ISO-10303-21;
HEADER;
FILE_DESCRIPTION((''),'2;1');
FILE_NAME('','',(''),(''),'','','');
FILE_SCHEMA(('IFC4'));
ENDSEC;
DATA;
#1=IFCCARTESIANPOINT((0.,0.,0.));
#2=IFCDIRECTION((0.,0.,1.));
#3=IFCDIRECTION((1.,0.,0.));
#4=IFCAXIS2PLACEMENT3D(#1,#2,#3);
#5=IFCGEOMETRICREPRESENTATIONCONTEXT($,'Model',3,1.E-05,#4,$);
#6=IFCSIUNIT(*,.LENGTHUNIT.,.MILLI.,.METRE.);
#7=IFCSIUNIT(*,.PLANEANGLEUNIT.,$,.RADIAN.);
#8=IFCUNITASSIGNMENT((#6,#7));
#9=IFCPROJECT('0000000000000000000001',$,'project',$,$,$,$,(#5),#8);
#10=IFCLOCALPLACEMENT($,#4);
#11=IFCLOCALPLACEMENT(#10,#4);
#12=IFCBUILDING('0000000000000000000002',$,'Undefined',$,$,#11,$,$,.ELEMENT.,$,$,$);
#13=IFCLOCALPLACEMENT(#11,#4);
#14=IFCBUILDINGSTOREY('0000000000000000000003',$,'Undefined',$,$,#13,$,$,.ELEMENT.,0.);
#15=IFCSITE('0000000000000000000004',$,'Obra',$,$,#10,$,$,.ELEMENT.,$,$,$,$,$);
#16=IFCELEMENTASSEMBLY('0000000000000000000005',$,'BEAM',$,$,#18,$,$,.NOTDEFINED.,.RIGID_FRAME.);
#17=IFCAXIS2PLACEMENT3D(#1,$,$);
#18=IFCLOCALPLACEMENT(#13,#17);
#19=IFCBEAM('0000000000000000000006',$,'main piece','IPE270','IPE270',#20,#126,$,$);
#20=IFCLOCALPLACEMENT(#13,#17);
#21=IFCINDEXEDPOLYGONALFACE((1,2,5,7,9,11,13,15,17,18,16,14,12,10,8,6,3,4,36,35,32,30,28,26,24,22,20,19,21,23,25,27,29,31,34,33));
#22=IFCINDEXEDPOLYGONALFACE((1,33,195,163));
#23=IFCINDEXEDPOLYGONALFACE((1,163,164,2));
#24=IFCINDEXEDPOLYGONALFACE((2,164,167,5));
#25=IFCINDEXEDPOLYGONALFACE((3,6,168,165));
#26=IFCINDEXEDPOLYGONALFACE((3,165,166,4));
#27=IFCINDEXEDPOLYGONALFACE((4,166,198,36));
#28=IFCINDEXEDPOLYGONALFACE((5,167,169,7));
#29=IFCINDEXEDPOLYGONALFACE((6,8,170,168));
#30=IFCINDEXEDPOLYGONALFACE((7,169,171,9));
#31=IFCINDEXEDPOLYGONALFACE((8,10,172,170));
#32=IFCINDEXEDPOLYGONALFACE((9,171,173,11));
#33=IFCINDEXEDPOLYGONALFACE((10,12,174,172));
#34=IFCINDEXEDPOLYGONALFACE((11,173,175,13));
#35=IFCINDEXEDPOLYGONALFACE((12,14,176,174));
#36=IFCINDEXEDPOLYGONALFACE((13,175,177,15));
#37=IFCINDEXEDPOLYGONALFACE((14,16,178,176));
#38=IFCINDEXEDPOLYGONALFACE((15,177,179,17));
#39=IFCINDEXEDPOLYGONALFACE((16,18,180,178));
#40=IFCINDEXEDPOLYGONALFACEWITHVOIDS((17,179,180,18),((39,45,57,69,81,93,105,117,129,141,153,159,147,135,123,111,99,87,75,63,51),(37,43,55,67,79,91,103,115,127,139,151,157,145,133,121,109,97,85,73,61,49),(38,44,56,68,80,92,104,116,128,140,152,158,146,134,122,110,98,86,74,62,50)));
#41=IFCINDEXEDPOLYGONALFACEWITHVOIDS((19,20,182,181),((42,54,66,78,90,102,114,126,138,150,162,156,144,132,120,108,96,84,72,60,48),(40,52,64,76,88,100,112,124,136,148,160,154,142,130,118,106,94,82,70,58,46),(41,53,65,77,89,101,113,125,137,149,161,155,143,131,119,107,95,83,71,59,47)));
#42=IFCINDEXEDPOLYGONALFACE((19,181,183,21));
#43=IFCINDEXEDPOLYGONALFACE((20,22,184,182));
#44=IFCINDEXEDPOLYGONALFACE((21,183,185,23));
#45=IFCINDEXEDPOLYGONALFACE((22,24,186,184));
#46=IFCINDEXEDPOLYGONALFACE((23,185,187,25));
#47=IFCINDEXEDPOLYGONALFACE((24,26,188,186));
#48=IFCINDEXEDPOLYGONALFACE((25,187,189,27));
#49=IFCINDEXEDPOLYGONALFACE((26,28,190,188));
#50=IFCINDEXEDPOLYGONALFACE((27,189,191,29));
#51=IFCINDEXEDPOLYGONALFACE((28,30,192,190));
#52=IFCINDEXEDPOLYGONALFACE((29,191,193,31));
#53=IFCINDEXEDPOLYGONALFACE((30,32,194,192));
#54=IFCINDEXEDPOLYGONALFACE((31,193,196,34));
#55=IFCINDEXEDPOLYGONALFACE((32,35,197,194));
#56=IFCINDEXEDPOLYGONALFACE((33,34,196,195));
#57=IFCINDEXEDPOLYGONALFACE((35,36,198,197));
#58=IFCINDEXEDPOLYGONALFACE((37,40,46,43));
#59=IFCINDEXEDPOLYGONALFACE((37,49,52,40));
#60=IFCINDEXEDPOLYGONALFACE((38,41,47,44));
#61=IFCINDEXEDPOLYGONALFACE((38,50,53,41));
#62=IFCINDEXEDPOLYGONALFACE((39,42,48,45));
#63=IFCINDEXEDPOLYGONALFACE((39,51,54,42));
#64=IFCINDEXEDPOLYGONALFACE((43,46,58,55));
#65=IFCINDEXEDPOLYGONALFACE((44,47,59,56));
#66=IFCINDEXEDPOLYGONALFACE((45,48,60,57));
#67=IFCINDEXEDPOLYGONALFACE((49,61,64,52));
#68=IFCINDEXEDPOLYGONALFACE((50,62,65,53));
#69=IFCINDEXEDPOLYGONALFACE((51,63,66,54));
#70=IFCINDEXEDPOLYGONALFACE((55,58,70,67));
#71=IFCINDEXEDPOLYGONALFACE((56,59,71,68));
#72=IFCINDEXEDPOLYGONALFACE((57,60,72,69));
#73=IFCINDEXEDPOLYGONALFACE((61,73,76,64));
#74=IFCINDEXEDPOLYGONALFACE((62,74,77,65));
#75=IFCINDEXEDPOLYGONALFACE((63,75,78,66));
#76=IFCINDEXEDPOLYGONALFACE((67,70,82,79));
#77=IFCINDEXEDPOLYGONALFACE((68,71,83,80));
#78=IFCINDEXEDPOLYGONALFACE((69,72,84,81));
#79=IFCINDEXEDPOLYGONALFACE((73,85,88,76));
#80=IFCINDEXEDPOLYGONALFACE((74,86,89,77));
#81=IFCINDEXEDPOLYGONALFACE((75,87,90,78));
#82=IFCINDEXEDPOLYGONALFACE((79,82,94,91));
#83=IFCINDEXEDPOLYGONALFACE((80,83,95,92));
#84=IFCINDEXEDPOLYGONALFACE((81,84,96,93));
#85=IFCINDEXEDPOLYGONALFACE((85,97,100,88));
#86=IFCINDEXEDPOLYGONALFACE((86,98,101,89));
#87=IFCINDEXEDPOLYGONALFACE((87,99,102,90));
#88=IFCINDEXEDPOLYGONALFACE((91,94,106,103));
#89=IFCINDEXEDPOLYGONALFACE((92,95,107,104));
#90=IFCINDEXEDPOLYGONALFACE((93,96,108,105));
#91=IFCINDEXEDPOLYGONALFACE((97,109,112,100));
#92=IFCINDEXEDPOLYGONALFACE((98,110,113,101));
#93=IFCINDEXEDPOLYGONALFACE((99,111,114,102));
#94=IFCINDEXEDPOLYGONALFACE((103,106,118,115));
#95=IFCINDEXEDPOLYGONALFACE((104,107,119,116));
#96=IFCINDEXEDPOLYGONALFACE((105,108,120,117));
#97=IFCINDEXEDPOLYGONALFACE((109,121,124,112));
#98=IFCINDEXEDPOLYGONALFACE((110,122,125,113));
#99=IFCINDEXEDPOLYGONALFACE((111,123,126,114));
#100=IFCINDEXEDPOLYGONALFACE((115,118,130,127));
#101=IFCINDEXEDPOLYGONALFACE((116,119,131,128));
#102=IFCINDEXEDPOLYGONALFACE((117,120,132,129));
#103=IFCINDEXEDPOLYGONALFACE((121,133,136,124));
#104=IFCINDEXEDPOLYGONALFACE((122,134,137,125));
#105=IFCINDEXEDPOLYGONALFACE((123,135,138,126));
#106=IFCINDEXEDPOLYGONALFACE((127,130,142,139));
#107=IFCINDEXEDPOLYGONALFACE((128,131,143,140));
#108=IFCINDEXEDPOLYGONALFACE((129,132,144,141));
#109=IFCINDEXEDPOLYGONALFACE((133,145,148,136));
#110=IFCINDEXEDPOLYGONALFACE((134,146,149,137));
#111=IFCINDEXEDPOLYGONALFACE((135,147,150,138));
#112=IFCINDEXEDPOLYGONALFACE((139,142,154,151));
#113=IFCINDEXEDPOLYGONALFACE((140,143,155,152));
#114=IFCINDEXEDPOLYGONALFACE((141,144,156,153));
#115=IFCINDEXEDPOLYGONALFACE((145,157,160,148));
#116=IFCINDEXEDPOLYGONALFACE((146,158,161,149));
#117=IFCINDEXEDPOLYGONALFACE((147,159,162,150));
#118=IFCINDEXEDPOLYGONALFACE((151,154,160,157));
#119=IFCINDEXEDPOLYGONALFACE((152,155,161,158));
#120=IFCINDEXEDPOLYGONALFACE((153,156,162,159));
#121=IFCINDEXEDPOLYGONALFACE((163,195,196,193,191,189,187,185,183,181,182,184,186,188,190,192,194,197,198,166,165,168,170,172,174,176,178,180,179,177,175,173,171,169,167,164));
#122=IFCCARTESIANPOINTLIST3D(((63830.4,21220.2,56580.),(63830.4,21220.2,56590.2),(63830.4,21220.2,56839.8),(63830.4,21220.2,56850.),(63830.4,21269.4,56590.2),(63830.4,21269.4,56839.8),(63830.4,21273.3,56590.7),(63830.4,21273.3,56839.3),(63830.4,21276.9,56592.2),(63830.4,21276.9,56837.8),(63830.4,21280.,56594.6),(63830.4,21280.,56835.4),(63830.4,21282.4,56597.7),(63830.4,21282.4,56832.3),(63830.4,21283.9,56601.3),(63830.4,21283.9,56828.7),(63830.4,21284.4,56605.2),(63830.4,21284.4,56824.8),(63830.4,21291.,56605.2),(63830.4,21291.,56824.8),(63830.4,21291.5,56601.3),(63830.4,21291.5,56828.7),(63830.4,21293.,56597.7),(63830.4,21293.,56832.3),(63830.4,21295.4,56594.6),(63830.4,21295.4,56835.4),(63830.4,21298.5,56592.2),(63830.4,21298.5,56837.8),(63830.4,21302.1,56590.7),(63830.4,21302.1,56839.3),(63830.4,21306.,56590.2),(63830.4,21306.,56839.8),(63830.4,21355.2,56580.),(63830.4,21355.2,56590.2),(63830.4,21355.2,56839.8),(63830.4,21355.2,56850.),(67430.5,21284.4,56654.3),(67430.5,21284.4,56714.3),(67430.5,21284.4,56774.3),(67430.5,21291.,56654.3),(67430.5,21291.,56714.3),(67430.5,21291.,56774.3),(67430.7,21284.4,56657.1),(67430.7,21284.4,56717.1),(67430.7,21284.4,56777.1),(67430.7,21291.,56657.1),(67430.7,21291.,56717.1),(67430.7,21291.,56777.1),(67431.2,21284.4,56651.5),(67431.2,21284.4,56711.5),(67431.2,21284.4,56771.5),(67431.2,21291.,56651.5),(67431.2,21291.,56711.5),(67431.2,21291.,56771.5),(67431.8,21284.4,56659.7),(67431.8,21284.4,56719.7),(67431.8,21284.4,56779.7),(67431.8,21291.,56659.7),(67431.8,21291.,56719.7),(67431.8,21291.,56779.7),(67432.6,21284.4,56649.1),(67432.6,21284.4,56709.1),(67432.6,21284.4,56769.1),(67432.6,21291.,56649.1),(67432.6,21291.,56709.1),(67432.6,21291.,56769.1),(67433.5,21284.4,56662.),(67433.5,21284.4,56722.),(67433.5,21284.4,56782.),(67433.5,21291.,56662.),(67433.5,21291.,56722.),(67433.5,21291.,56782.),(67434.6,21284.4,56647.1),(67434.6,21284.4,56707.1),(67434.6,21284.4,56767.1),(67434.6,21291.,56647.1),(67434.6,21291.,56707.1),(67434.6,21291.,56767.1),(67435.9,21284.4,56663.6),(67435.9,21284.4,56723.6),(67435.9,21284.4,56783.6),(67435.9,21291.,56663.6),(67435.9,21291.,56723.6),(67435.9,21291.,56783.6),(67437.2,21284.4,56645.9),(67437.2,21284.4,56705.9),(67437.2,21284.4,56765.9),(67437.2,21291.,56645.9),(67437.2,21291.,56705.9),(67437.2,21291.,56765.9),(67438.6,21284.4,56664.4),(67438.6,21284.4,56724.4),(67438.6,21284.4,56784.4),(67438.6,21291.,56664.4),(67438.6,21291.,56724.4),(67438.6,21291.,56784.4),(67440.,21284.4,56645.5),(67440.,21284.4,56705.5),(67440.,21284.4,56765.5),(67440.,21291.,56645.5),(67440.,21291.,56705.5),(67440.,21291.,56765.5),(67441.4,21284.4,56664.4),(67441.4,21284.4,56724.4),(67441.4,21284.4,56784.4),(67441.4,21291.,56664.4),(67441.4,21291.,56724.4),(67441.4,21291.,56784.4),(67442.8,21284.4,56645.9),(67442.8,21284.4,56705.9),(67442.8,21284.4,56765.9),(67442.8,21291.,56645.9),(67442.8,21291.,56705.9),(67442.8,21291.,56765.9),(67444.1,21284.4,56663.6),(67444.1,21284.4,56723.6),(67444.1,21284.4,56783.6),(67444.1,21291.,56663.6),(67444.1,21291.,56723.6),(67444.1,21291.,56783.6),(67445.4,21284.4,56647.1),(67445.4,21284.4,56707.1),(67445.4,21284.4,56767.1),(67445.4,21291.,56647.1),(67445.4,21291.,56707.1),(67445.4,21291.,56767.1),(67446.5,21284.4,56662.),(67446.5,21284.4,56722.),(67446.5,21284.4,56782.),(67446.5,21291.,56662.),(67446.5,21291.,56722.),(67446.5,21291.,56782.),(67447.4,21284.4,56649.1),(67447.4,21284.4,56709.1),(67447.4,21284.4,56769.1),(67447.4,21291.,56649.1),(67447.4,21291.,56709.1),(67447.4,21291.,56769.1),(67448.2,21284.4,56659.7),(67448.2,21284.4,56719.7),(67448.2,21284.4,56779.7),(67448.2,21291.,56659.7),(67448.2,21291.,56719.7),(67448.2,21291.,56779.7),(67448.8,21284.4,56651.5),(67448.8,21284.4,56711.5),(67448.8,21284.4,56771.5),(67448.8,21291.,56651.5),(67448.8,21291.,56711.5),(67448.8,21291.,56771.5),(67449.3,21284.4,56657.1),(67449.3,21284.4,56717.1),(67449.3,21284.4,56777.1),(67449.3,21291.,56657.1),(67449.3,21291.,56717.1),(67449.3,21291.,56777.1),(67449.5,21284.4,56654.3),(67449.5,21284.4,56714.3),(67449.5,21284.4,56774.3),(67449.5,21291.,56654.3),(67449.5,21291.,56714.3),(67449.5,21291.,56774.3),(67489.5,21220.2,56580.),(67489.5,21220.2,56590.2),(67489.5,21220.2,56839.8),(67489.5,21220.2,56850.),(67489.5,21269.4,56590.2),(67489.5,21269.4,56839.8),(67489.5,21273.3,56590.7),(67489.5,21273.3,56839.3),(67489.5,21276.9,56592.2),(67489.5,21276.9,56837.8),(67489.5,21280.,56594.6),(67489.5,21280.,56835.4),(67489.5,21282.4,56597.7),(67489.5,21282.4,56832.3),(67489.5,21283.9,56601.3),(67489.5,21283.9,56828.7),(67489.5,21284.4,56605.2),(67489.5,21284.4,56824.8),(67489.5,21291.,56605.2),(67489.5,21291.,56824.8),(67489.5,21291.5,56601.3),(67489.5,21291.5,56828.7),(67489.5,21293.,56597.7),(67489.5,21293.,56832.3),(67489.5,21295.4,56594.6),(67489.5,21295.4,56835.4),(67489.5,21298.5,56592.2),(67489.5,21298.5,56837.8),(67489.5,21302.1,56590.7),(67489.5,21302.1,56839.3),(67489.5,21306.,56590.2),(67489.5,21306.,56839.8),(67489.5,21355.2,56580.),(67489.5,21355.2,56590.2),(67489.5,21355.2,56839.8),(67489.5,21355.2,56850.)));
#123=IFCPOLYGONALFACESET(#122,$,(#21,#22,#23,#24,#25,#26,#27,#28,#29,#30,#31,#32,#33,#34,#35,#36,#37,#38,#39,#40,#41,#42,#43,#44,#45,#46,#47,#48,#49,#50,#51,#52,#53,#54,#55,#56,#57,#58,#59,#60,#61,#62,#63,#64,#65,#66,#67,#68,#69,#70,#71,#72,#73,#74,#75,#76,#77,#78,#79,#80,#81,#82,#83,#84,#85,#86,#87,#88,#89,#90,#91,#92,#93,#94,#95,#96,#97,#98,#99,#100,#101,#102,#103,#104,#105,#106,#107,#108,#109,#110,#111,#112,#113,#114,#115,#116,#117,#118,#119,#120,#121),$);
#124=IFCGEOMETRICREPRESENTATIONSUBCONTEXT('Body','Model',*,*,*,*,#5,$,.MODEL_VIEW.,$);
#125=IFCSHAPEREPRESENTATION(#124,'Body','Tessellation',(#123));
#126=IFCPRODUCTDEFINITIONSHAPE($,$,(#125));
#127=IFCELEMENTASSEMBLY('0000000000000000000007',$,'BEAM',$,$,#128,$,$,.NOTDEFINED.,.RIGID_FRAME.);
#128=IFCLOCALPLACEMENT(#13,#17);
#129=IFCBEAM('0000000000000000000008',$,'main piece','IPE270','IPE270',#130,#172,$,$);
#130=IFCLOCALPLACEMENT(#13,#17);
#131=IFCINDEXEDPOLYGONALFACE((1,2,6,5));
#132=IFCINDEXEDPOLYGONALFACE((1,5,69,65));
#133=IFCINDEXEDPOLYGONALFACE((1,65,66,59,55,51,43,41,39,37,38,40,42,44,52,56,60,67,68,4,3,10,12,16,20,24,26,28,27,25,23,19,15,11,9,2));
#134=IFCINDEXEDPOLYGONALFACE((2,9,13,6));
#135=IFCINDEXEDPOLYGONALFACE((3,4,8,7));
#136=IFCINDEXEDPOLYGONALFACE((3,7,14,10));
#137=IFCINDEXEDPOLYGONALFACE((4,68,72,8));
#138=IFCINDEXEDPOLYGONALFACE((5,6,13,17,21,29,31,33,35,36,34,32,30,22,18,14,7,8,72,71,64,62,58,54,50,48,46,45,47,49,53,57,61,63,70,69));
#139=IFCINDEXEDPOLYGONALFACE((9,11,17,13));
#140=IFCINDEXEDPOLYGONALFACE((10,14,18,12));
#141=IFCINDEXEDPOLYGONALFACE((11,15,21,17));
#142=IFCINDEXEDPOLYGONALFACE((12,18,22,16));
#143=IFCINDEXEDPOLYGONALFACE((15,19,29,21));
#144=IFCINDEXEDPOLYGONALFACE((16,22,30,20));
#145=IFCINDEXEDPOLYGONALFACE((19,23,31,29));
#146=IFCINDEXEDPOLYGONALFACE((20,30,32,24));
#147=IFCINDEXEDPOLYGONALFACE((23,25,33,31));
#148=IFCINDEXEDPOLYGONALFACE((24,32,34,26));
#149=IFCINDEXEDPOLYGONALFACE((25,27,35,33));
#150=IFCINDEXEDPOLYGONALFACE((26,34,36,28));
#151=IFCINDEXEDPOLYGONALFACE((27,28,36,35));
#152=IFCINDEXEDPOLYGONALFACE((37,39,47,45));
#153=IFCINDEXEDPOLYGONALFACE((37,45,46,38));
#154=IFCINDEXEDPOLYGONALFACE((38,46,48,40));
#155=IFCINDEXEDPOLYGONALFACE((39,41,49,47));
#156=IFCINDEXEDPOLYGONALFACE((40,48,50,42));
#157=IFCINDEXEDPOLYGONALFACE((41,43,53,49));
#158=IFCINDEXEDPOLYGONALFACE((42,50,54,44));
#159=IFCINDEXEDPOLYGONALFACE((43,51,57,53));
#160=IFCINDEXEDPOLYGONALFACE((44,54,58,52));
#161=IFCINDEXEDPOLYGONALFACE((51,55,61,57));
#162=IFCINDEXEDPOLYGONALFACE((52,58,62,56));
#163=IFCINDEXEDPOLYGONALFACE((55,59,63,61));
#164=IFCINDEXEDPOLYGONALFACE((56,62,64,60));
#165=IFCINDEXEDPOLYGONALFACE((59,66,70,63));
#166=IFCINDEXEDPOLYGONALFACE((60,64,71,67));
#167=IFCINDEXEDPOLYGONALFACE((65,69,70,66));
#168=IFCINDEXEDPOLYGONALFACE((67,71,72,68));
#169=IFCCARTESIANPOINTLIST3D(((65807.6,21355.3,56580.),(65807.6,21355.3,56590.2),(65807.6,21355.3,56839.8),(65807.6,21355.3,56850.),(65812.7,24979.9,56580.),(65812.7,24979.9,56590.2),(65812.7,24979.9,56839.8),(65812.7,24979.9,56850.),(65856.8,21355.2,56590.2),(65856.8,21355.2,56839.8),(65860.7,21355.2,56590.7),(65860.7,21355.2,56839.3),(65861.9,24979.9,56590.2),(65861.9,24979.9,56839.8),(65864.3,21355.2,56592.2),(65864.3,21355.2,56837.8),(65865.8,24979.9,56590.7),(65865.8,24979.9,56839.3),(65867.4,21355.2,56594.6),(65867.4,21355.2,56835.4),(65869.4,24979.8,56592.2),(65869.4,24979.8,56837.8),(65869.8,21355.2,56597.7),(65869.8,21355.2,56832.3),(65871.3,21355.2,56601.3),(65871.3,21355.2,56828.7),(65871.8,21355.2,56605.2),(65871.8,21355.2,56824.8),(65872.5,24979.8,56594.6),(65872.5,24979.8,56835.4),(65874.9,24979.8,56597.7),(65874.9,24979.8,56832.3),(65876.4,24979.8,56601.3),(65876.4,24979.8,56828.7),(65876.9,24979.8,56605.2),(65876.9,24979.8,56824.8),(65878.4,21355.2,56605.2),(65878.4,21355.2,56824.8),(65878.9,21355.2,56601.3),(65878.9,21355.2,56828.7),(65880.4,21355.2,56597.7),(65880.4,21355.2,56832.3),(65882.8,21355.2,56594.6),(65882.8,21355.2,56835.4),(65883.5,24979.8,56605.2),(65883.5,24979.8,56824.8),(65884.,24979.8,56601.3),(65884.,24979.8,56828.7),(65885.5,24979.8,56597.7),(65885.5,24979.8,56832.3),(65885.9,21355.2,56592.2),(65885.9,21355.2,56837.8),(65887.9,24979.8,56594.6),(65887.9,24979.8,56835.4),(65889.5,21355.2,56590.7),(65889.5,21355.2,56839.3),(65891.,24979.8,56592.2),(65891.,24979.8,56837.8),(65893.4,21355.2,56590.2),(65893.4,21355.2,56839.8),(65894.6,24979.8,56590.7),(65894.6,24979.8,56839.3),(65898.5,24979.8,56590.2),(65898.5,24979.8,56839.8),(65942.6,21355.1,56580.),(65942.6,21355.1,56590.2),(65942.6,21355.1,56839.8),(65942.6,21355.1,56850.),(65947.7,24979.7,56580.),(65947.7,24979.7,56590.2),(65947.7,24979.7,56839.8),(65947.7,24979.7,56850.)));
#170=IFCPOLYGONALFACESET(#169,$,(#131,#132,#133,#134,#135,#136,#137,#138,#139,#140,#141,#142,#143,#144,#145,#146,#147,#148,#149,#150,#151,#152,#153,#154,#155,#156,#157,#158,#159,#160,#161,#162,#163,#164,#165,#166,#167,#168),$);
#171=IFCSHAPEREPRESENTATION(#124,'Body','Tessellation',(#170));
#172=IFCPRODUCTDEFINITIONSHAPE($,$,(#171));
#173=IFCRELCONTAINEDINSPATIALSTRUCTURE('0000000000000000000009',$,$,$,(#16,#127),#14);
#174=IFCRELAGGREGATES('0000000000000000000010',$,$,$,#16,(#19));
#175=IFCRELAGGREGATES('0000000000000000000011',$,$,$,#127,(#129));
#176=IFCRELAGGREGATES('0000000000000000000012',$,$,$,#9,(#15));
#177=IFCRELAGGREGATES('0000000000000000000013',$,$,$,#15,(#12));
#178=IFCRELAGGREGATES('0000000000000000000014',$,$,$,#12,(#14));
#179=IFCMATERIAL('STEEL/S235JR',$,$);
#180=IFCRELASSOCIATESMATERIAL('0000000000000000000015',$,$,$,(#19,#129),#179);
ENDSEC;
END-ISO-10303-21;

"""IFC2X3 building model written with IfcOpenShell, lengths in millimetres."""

from ifc_helpers import new_model, si_unit, frame, origin_with_axes, origin_2d_with_axis, place, context, subcontext, project, spatial, circle, i_section, extrude, clip, halfspace, source, transform, mapped, material, element, aggregate, save


model = new_model("IFC2X3")

# Units and contexts
model_context = context("Model", 3, precision=1e-05, world=origin_with_axes())
body_context = subcontext(model_context, "Body", "Model", "MODEL_VIEW")
ifc_project = project(units=[si_unit("LENGTHUNIT", "METRE", prefix="MILLI"), si_unit("PLANEANGLEUNIT", "RADIAN")], contexts=[model_context])

# Site, building, storey
site_placement = place(None, origin_with_axes())
site = spatial("IfcSite", under=ifc_project, at=site_placement, Name="Obra", CompositionType="ELEMENT")
building_placement = place(site_placement, origin_with_axes())
building = spatial("IfcBuilding", under=site, at=building_placement, Name="Undefined", CompositionType="ELEMENT")
storey_placement = place(building_placement, origin_with_axes())
storey = spatial("IfcBuildingStorey", under=building, at=storey_placement, Name="Undefined", CompositionType="ELEMENT", Elevation=0.0)

# Shared definitions
ifc_material_1 = material(Name="STEEL/S235JR")

# Shared definitions
shared_shape_1 = source(origin_with_axes(), body_context, "Body", "SweptSolid", [
    extrude(circle(Radius=9.5, at=origin_2d_with_axis()), frame((0.0, -3.4, 0.0), z_axis=(0.0, 1.0, 0.0), x_axis=(1.0, 0.0, 0.0)), (0.0, 0.0, 1.0), 6.8),
])

# Element assembly, beam, opening
assembly_1_placement = place(storey_placement, origin_with_axes())
assembly_1 = element("IfcElementAssembly", 1, at=assembly_1_placement, inside=storey, Name="BEAM", AssemblyPlace="NOTDEFINED", PredefinedType="RIGID_FRAME")
beam_1_placement = place(assembly_1_placement, frame((63830.4, 21287.7, 56715.0), z_axis=(0.0, 0.0, 1.0), x_axis=(1.0, 0.000002, 0.0)))
beam_1 = element("IfcBeam", 2, at=beam_1_placement, material=ifc_material_1, Name="main piece", Description="IPE270", ObjectType="IPE270", context=body_context, shape_type="Clipping", body=[
    clip(extrude(i_section(OverallWidth=135.0, OverallDepth=270.0, WebThickness=6.6, FlangeThickness=10.2, FilletRadius=15.0, at=origin_2d_with_axis()), frame((3843.2, 0.0, 0.0), z_axis=(-1.0, 0.0, 0.0), x_axis=(0.0, -1.0, 0.0)), (0.0, 0.0, 1.0), 3843.2), halfspace(frame((3659.1, -60.0, -120.0), z_axis=(1.0, 0.000017, 0.0), x_axis=(0.0, 0.0, 1.0)), False)),
])
opening_1_placement = place(assembly_1_placement, frame((67490.0, 21287.7, 56835.0), z_axis=(-1.0, 0.0, 0.0), x_axis=(0.0, 0.0, -1.0)))
element("IfcOpeningElement", 3, at=opening_1_placement, cuts=beam_1, ObjectType="Opening", context=body_context, shape_type="MappedRepresentation", body=[
    mapped(shared_shape_1, transform((60.0, 0.0, 50.0))),
    mapped(shared_shape_1, transform((120.0, 0.0, 50.0))),
    mapped(shared_shape_1, transform((180.0, 0.0, 50.0))),
])
aggregate(assembly_1, [beam_1])

# Element assembly, beam
assembly_2_placement = place(storey_placement, origin_with_axes())
assembly_2 = element("IfcElementAssembly", 4, at=assembly_2_placement, inside=storey, Name="BEAM", AssemblyPlace="NOTDEFINED", PredefinedType="RIGID_FRAME")
beam_2_placement = place(assembly_2_placement, frame((65880.2, 24979.8, 56715.0), z_axis=(0.0, 0.0, 1.0), x_axis=(-0.001409, -0.999999, 0.0)))
beam_2 = element("IfcBeam", 5, at=beam_2_placement, material=ifc_material_1, Name="main piece", Description="IPE270", ObjectType="IPE270", context=body_context, shape_type="SweptSolid", body=[
    extrude(i_section(OverallWidth=135.0, OverallDepth=270.0, WebThickness=6.6, FlangeThickness=10.2, FilletRadius=15.0, at=origin_2d_with_axis()), frame((3624.6, 0.0, 0.0), z_axis=(-1.0, 0.0, 0.0), x_axis=(0.0, -1.0, 0.0)), (0.0, 0.0, 1.0), 3624.6),
])
aggregate(assembly_2, [beam_2])

save(model, "model.ifc")
